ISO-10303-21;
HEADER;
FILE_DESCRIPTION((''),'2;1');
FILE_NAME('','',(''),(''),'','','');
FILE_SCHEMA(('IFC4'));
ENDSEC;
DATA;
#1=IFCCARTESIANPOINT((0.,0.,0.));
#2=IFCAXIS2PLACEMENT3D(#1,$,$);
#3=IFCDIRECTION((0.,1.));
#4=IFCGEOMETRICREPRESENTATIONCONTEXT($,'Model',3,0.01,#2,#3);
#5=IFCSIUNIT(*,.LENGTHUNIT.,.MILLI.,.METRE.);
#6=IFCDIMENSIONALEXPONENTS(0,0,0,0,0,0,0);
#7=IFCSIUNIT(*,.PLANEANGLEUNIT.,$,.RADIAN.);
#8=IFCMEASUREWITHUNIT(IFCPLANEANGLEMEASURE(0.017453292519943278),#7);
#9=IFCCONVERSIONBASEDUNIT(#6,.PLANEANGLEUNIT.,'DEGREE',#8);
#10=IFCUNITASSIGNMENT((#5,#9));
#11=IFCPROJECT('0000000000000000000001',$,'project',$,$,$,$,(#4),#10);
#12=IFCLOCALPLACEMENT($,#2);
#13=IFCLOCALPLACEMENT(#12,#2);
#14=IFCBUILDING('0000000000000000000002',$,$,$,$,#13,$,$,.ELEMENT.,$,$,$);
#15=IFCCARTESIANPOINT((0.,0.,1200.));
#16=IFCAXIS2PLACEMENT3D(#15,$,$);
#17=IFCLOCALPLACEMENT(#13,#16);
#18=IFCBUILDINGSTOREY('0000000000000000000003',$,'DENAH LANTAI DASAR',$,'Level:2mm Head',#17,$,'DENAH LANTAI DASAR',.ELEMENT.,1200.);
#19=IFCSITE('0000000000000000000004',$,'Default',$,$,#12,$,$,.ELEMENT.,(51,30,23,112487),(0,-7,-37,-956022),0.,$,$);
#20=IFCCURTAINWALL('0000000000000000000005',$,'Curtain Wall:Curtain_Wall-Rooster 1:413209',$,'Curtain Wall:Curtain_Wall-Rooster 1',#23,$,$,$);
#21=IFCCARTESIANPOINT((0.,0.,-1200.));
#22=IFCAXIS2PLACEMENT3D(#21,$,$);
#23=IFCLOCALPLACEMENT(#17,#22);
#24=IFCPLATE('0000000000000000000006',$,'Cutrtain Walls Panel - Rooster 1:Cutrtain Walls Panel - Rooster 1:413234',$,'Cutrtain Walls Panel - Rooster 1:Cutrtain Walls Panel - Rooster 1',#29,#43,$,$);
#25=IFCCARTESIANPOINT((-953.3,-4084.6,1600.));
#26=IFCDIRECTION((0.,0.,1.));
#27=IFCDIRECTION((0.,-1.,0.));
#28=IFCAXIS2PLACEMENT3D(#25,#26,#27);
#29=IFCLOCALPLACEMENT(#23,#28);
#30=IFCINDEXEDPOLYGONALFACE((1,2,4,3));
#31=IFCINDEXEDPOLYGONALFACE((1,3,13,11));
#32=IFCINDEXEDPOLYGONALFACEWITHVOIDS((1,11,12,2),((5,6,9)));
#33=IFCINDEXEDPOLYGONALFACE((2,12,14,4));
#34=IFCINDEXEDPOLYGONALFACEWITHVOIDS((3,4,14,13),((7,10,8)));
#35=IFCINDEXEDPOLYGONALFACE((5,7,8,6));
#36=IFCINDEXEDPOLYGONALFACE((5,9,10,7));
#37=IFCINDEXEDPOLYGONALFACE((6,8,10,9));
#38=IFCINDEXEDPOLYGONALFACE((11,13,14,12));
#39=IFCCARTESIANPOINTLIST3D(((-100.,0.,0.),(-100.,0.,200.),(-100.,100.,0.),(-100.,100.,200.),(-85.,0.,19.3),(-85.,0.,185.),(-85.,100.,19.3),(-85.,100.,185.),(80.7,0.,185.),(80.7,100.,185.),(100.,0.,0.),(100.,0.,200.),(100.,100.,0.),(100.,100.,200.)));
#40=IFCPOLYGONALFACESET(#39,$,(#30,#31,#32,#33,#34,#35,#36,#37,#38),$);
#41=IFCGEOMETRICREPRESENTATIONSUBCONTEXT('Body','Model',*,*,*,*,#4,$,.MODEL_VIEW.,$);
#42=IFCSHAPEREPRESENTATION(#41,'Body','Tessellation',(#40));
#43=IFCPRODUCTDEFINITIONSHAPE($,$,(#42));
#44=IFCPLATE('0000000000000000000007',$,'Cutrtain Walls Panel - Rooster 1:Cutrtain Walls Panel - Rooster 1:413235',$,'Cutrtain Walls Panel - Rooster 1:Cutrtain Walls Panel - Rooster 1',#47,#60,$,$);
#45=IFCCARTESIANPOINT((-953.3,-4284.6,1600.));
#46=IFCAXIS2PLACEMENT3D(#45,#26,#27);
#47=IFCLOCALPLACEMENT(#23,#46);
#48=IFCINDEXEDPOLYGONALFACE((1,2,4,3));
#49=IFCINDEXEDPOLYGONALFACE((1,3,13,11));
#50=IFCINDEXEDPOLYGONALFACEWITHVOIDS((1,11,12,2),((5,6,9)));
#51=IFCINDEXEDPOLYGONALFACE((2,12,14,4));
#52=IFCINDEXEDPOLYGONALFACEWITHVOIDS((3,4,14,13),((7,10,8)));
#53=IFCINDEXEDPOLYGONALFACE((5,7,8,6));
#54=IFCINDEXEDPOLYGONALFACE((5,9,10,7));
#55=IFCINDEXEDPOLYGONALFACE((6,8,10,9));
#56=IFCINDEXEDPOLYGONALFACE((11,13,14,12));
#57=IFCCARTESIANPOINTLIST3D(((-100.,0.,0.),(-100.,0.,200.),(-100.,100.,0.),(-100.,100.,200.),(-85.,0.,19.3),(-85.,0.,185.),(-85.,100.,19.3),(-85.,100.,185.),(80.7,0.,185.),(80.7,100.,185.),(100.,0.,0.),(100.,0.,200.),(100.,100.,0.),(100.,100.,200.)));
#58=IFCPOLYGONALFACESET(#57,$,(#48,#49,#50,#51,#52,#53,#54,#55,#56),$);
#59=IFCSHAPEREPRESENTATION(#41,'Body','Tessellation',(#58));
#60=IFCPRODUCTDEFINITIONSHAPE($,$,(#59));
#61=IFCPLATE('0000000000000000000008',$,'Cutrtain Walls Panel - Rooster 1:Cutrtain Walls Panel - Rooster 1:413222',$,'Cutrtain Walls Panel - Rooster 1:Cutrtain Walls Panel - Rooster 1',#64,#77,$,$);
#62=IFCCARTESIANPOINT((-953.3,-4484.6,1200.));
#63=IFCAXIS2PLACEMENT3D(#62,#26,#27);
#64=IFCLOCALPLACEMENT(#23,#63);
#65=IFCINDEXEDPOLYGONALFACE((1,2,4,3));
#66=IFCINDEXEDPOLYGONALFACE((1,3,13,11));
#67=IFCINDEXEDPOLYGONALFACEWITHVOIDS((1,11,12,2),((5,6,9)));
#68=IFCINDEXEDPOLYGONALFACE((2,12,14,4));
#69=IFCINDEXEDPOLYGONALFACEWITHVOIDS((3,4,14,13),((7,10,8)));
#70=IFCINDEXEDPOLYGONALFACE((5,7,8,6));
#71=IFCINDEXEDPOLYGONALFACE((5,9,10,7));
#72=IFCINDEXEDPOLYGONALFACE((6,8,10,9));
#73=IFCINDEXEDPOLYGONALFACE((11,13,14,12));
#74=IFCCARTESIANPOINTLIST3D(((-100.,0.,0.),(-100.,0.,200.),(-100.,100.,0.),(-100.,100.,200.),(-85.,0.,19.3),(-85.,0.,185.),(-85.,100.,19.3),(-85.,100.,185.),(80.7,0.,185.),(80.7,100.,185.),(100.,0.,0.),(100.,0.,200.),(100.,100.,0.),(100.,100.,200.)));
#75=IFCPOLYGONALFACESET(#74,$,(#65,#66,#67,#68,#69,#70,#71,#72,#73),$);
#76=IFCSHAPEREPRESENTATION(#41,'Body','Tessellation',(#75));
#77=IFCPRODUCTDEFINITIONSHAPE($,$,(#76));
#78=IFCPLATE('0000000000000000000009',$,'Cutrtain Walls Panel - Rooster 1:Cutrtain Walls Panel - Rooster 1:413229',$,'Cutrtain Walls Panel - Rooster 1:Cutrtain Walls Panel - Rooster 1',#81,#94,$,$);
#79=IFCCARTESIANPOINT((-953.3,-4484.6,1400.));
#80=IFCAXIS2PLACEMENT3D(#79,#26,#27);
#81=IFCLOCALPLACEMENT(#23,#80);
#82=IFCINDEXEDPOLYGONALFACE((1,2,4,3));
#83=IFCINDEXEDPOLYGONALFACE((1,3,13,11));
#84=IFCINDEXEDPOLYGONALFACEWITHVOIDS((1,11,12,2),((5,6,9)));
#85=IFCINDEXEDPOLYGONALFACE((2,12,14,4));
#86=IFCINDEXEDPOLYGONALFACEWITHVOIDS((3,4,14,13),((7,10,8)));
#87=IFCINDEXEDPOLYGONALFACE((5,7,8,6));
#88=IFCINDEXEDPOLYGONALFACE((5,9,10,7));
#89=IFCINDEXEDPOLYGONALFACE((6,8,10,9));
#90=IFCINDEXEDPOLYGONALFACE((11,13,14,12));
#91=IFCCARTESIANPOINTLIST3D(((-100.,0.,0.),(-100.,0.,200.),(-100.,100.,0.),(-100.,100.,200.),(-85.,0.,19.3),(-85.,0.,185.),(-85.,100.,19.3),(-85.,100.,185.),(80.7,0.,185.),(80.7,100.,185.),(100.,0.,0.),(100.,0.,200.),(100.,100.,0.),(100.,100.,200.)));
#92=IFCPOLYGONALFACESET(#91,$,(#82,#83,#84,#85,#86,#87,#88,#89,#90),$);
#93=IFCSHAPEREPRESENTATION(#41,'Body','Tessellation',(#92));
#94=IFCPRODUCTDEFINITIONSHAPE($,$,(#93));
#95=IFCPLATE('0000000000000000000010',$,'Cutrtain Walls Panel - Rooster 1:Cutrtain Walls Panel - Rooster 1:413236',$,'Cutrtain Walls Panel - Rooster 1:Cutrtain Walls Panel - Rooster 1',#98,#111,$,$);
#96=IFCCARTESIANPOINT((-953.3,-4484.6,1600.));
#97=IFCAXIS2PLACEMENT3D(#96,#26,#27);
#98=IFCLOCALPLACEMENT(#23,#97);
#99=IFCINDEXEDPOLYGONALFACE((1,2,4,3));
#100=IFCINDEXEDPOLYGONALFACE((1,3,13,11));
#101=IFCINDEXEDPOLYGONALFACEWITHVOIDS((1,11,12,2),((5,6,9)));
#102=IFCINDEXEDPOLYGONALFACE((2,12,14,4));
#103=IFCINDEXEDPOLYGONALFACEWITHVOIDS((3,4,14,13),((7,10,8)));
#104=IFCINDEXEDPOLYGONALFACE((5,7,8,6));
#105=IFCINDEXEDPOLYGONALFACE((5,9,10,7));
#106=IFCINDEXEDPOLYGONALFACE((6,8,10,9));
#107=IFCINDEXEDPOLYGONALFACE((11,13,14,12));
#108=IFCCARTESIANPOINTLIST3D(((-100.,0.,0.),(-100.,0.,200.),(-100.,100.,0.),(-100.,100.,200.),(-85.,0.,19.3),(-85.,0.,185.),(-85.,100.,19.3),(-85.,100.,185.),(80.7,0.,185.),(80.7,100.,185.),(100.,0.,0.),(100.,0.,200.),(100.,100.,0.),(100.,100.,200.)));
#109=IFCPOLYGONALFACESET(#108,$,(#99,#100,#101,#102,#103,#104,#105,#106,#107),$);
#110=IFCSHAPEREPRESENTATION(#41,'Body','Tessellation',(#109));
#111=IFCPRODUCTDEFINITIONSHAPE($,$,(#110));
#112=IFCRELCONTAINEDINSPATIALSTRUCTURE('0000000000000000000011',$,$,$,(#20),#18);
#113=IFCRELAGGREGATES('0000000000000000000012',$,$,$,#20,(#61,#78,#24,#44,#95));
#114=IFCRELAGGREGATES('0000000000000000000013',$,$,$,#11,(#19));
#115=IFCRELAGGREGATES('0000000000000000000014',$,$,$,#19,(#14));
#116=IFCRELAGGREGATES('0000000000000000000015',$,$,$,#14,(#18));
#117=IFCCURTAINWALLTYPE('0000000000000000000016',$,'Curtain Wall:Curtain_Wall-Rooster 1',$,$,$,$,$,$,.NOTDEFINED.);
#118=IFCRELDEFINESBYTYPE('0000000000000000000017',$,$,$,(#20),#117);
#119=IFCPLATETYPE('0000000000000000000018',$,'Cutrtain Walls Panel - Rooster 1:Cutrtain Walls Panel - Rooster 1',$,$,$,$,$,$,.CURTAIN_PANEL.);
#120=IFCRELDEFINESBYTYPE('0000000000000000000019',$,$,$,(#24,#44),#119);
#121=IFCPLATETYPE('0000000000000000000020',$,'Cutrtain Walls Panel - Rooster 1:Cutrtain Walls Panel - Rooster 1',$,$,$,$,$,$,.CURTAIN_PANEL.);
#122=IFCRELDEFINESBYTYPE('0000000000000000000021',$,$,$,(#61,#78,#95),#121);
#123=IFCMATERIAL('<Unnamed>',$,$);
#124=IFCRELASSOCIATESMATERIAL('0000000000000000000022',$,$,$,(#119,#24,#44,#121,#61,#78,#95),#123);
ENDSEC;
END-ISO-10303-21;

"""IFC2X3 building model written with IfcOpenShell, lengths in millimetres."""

from ifc_helpers import new_model, entity, si_unit, converted_unit, direction, frame, origin, place, context, subcontext, project, spatial, polyline, outline, extrude, source, transform, mapped, material, type_object, type_shapes, element, aggregate, save


model = new_model("IFC2X3")

# Units and contexts
model_context = context("Model", 3, precision=0.01, world=origin(), true_north=direction((0.0, 1.0)))
body_context = subcontext(model_context, "Body", "Model", "MODEL_VIEW")
ifc_project = project(units=[si_unit("LENGTHUNIT", "METRE", prefix="MILLI"), converted_unit("PLANEANGLEUNIT", "DEGREE", entity("IfcPlaneAngleMeasure", 0.017453292519943278), si_unit("PLANEANGLEUNIT", "RADIAN"), dimensions=[0, 0, 0, 0, 0, 0, 0])], contexts=[model_context])

# Site, building, storey
site_placement = place(None, origin())
site = spatial("IfcSite", under=ifc_project, at=site_placement, Name="Default", CompositionType="ELEMENT", RefLatitude=(51, 30, 23, 112487), RefLongitude=(0, -7, -37, -956022), RefElevation=0.0)
building_placement = place(site_placement, origin())
building = spatial("IfcBuilding", under=site, at=building_placement, CompositionType="ELEMENT")
storey_placement = place(building_placement, frame((0.0, 0.0, 1200.0)))
storey = spatial("IfcBuildingStorey", under=building, at=storey_placement, Name="DENAH LANTAI DASAR", ObjectType="Level:2mm Head", LongName="DENAH LANTAI DASAR", CompositionType="ELEMENT", Elevation=1200.0)

# Curtain wall, plates
curtain_wall_type = type_object("IfcCurtainWallType", Name="Curtain Wall:Curtain_Wall-Rooster 1", PredefinedType="NOTDEFINED")
ifc_material = material(Name="<Unnamed>")
plate_type_1 = type_object("IfcPlateType", Name="Cutrtain Walls Panel - Rooster 1:Cutrtain Walls Panel - Rooster 1", PredefinedType="CURTAIN_PANEL", material=ifc_material)
shared_shape_1 = source(origin(), body_context, "Body", "SweptSolid", [
    extrude(outline(polyline([(-100.0, -100.0), (100.0, -100.0), (100.0, 100.0), (-100.0, 100.0), (-100.0, -100.0)]), holes=[polyline([(80.7, 85.0), (-85.0, -80.7), (-85.0, 85.0), (80.7, 85.0)])]), frame((0.0, 0.0, 100.0), z_axis=(0.0, 1.0, 0.0), x_axis=(0.0, 0.0, -1.0)), (0.0, 0.0, 1.0), 100.0),
])
type_shapes(plate_type_1, [shared_shape_1])
curtain_wall_1_placement = place(storey_placement, frame((0.0, 0.0, -1200.0)))
curtain_wall_1 = element("IfcCurtainWall", 1, at=curtain_wall_1_placement, inside=storey, type_object=curtain_wall_type, Name="Curtain Wall:Curtain_Wall-Rooster 1:413209", ObjectType="Curtain Wall:Curtain_Wall-Rooster 1")
plate_1_placement = place(curtain_wall_1_placement, frame((-953.3, -4084.6, 1600.0), z_axis=(0.0, 0.0, 1.0), x_axis=(0.0, -1.0, 0.0)))
plate_1 = element("IfcPlate", 2, at=plate_1_placement, type_object=plate_type_1, material=ifc_material, Name="Cutrtain Walls Panel - Rooster 1:Cutrtain Walls Panel - Rooster 1:413234", ObjectType="Cutrtain Walls Panel - Rooster 1:Cutrtain Walls Panel - Rooster 1", context=body_context, shape_type="MappedRepresentation", body=[
    mapped(shared_shape_1, transform((0.0, 0.0, 0.0), scale=1.0)),
])
plate_2_placement = place(curtain_wall_1_placement, frame((-953.3, -4284.6, 1600.0), z_axis=(0.0, 0.0, 1.0), x_axis=(0.0, -1.0, 0.0)))
plate_2 = element("IfcPlate", 3, at=plate_2_placement, type_object=plate_type_1, material=ifc_material, Name="Cutrtain Walls Panel - Rooster 1:Cutrtain Walls Panel - Rooster 1:413235", ObjectType="Cutrtain Walls Panel - Rooster 1:Cutrtain Walls Panel - Rooster 1", context=body_context, shape_type="MappedRepresentation", body=[
    mapped(shared_shape_1, transform((0.0, 0.0, 0.0), scale=1.0)),
])
plate_type_2 = type_object("IfcPlateType", Name="Cutrtain Walls Panel - Rooster 1:Cutrtain Walls Panel - Rooster 1", PredefinedType="CURTAIN_PANEL", material=ifc_material)
shared_shape_2 = source(origin(), body_context, "Body", "SweptSolid", [
    extrude(outline(polyline([(-100.0, -100.0), (100.0, -100.0), (100.0, 100.0), (-100.0, 100.0), (-100.0, -100.0)]), holes=[polyline([(80.7, 85.0), (-85.0, -80.7), (-85.0, 85.0), (80.7, 85.0)])]), frame((0.0, 0.0, 100.0), z_axis=(0.0, 1.0, 0.0), x_axis=(0.0, 0.0, -1.0)), (0.0, 0.0, 1.0), 100.0),
])
type_shapes(plate_type_2, [shared_shape_2])
plate_3_placement = place(curtain_wall_1_placement, frame((-953.3, -4484.6, 1200.0), z_axis=(0.0, 0.0, 1.0), x_axis=(0.0, -1.0, 0.0)))
plate_3 = element("IfcPlate", 4, at=plate_3_placement, type_object=plate_type_2, material=ifc_material, Name="Cutrtain Walls Panel - Rooster 1:Cutrtain Walls Panel - Rooster 1:413222", ObjectType="Cutrtain Walls Panel - Rooster 1:Cutrtain Walls Panel - Rooster 1", context=body_context, shape_type="MappedRepresentation", body=[
    mapped(shared_shape_2, transform((0.0, 0.0, 0.0), scale=1.0)),
])
plate_4_placement = place(curtain_wall_1_placement, frame((-953.3, -4484.6, 1400.0), z_axis=(0.0, 0.0, 1.0), x_axis=(0.0, -1.0, 0.0)))
plate_4 = element("IfcPlate", 5, at=plate_4_placement, type_object=plate_type_2, material=ifc_material, Name="Cutrtain Walls Panel - Rooster 1:Cutrtain Walls Panel - Rooster 1:413229", ObjectType="Cutrtain Walls Panel - Rooster 1:Cutrtain Walls Panel - Rooster 1", context=body_context, shape_type="MappedRepresentation", body=[
    mapped(shared_shape_2, transform((0.0, 0.0, 0.0), scale=1.0)),
])
plate_5_placement = place(curtain_wall_1_placement, frame((-953.3, -4484.6, 1600.0), z_axis=(0.0, 0.0, 1.0), x_axis=(0.0, -1.0, 0.0)))
plate_5 = element("IfcPlate", 6, at=plate_5_placement, type_object=plate_type_2, material=ifc_material, Name="Cutrtain Walls Panel - Rooster 1:Cutrtain Walls Panel - Rooster 1:413236", ObjectType="Cutrtain Walls Panel - Rooster 1:Cutrtain Walls Panel - Rooster 1", context=body_context, shape_type="MappedRepresentation", body=[
    mapped(shared_shape_2, transform((0.0, 0.0, 0.0), scale=1.0)),
])
aggregate(curtain_wall_1, [plate_3, plate_4, plate_1, plate_2, plate_5])

save(model, "model.ifc")
